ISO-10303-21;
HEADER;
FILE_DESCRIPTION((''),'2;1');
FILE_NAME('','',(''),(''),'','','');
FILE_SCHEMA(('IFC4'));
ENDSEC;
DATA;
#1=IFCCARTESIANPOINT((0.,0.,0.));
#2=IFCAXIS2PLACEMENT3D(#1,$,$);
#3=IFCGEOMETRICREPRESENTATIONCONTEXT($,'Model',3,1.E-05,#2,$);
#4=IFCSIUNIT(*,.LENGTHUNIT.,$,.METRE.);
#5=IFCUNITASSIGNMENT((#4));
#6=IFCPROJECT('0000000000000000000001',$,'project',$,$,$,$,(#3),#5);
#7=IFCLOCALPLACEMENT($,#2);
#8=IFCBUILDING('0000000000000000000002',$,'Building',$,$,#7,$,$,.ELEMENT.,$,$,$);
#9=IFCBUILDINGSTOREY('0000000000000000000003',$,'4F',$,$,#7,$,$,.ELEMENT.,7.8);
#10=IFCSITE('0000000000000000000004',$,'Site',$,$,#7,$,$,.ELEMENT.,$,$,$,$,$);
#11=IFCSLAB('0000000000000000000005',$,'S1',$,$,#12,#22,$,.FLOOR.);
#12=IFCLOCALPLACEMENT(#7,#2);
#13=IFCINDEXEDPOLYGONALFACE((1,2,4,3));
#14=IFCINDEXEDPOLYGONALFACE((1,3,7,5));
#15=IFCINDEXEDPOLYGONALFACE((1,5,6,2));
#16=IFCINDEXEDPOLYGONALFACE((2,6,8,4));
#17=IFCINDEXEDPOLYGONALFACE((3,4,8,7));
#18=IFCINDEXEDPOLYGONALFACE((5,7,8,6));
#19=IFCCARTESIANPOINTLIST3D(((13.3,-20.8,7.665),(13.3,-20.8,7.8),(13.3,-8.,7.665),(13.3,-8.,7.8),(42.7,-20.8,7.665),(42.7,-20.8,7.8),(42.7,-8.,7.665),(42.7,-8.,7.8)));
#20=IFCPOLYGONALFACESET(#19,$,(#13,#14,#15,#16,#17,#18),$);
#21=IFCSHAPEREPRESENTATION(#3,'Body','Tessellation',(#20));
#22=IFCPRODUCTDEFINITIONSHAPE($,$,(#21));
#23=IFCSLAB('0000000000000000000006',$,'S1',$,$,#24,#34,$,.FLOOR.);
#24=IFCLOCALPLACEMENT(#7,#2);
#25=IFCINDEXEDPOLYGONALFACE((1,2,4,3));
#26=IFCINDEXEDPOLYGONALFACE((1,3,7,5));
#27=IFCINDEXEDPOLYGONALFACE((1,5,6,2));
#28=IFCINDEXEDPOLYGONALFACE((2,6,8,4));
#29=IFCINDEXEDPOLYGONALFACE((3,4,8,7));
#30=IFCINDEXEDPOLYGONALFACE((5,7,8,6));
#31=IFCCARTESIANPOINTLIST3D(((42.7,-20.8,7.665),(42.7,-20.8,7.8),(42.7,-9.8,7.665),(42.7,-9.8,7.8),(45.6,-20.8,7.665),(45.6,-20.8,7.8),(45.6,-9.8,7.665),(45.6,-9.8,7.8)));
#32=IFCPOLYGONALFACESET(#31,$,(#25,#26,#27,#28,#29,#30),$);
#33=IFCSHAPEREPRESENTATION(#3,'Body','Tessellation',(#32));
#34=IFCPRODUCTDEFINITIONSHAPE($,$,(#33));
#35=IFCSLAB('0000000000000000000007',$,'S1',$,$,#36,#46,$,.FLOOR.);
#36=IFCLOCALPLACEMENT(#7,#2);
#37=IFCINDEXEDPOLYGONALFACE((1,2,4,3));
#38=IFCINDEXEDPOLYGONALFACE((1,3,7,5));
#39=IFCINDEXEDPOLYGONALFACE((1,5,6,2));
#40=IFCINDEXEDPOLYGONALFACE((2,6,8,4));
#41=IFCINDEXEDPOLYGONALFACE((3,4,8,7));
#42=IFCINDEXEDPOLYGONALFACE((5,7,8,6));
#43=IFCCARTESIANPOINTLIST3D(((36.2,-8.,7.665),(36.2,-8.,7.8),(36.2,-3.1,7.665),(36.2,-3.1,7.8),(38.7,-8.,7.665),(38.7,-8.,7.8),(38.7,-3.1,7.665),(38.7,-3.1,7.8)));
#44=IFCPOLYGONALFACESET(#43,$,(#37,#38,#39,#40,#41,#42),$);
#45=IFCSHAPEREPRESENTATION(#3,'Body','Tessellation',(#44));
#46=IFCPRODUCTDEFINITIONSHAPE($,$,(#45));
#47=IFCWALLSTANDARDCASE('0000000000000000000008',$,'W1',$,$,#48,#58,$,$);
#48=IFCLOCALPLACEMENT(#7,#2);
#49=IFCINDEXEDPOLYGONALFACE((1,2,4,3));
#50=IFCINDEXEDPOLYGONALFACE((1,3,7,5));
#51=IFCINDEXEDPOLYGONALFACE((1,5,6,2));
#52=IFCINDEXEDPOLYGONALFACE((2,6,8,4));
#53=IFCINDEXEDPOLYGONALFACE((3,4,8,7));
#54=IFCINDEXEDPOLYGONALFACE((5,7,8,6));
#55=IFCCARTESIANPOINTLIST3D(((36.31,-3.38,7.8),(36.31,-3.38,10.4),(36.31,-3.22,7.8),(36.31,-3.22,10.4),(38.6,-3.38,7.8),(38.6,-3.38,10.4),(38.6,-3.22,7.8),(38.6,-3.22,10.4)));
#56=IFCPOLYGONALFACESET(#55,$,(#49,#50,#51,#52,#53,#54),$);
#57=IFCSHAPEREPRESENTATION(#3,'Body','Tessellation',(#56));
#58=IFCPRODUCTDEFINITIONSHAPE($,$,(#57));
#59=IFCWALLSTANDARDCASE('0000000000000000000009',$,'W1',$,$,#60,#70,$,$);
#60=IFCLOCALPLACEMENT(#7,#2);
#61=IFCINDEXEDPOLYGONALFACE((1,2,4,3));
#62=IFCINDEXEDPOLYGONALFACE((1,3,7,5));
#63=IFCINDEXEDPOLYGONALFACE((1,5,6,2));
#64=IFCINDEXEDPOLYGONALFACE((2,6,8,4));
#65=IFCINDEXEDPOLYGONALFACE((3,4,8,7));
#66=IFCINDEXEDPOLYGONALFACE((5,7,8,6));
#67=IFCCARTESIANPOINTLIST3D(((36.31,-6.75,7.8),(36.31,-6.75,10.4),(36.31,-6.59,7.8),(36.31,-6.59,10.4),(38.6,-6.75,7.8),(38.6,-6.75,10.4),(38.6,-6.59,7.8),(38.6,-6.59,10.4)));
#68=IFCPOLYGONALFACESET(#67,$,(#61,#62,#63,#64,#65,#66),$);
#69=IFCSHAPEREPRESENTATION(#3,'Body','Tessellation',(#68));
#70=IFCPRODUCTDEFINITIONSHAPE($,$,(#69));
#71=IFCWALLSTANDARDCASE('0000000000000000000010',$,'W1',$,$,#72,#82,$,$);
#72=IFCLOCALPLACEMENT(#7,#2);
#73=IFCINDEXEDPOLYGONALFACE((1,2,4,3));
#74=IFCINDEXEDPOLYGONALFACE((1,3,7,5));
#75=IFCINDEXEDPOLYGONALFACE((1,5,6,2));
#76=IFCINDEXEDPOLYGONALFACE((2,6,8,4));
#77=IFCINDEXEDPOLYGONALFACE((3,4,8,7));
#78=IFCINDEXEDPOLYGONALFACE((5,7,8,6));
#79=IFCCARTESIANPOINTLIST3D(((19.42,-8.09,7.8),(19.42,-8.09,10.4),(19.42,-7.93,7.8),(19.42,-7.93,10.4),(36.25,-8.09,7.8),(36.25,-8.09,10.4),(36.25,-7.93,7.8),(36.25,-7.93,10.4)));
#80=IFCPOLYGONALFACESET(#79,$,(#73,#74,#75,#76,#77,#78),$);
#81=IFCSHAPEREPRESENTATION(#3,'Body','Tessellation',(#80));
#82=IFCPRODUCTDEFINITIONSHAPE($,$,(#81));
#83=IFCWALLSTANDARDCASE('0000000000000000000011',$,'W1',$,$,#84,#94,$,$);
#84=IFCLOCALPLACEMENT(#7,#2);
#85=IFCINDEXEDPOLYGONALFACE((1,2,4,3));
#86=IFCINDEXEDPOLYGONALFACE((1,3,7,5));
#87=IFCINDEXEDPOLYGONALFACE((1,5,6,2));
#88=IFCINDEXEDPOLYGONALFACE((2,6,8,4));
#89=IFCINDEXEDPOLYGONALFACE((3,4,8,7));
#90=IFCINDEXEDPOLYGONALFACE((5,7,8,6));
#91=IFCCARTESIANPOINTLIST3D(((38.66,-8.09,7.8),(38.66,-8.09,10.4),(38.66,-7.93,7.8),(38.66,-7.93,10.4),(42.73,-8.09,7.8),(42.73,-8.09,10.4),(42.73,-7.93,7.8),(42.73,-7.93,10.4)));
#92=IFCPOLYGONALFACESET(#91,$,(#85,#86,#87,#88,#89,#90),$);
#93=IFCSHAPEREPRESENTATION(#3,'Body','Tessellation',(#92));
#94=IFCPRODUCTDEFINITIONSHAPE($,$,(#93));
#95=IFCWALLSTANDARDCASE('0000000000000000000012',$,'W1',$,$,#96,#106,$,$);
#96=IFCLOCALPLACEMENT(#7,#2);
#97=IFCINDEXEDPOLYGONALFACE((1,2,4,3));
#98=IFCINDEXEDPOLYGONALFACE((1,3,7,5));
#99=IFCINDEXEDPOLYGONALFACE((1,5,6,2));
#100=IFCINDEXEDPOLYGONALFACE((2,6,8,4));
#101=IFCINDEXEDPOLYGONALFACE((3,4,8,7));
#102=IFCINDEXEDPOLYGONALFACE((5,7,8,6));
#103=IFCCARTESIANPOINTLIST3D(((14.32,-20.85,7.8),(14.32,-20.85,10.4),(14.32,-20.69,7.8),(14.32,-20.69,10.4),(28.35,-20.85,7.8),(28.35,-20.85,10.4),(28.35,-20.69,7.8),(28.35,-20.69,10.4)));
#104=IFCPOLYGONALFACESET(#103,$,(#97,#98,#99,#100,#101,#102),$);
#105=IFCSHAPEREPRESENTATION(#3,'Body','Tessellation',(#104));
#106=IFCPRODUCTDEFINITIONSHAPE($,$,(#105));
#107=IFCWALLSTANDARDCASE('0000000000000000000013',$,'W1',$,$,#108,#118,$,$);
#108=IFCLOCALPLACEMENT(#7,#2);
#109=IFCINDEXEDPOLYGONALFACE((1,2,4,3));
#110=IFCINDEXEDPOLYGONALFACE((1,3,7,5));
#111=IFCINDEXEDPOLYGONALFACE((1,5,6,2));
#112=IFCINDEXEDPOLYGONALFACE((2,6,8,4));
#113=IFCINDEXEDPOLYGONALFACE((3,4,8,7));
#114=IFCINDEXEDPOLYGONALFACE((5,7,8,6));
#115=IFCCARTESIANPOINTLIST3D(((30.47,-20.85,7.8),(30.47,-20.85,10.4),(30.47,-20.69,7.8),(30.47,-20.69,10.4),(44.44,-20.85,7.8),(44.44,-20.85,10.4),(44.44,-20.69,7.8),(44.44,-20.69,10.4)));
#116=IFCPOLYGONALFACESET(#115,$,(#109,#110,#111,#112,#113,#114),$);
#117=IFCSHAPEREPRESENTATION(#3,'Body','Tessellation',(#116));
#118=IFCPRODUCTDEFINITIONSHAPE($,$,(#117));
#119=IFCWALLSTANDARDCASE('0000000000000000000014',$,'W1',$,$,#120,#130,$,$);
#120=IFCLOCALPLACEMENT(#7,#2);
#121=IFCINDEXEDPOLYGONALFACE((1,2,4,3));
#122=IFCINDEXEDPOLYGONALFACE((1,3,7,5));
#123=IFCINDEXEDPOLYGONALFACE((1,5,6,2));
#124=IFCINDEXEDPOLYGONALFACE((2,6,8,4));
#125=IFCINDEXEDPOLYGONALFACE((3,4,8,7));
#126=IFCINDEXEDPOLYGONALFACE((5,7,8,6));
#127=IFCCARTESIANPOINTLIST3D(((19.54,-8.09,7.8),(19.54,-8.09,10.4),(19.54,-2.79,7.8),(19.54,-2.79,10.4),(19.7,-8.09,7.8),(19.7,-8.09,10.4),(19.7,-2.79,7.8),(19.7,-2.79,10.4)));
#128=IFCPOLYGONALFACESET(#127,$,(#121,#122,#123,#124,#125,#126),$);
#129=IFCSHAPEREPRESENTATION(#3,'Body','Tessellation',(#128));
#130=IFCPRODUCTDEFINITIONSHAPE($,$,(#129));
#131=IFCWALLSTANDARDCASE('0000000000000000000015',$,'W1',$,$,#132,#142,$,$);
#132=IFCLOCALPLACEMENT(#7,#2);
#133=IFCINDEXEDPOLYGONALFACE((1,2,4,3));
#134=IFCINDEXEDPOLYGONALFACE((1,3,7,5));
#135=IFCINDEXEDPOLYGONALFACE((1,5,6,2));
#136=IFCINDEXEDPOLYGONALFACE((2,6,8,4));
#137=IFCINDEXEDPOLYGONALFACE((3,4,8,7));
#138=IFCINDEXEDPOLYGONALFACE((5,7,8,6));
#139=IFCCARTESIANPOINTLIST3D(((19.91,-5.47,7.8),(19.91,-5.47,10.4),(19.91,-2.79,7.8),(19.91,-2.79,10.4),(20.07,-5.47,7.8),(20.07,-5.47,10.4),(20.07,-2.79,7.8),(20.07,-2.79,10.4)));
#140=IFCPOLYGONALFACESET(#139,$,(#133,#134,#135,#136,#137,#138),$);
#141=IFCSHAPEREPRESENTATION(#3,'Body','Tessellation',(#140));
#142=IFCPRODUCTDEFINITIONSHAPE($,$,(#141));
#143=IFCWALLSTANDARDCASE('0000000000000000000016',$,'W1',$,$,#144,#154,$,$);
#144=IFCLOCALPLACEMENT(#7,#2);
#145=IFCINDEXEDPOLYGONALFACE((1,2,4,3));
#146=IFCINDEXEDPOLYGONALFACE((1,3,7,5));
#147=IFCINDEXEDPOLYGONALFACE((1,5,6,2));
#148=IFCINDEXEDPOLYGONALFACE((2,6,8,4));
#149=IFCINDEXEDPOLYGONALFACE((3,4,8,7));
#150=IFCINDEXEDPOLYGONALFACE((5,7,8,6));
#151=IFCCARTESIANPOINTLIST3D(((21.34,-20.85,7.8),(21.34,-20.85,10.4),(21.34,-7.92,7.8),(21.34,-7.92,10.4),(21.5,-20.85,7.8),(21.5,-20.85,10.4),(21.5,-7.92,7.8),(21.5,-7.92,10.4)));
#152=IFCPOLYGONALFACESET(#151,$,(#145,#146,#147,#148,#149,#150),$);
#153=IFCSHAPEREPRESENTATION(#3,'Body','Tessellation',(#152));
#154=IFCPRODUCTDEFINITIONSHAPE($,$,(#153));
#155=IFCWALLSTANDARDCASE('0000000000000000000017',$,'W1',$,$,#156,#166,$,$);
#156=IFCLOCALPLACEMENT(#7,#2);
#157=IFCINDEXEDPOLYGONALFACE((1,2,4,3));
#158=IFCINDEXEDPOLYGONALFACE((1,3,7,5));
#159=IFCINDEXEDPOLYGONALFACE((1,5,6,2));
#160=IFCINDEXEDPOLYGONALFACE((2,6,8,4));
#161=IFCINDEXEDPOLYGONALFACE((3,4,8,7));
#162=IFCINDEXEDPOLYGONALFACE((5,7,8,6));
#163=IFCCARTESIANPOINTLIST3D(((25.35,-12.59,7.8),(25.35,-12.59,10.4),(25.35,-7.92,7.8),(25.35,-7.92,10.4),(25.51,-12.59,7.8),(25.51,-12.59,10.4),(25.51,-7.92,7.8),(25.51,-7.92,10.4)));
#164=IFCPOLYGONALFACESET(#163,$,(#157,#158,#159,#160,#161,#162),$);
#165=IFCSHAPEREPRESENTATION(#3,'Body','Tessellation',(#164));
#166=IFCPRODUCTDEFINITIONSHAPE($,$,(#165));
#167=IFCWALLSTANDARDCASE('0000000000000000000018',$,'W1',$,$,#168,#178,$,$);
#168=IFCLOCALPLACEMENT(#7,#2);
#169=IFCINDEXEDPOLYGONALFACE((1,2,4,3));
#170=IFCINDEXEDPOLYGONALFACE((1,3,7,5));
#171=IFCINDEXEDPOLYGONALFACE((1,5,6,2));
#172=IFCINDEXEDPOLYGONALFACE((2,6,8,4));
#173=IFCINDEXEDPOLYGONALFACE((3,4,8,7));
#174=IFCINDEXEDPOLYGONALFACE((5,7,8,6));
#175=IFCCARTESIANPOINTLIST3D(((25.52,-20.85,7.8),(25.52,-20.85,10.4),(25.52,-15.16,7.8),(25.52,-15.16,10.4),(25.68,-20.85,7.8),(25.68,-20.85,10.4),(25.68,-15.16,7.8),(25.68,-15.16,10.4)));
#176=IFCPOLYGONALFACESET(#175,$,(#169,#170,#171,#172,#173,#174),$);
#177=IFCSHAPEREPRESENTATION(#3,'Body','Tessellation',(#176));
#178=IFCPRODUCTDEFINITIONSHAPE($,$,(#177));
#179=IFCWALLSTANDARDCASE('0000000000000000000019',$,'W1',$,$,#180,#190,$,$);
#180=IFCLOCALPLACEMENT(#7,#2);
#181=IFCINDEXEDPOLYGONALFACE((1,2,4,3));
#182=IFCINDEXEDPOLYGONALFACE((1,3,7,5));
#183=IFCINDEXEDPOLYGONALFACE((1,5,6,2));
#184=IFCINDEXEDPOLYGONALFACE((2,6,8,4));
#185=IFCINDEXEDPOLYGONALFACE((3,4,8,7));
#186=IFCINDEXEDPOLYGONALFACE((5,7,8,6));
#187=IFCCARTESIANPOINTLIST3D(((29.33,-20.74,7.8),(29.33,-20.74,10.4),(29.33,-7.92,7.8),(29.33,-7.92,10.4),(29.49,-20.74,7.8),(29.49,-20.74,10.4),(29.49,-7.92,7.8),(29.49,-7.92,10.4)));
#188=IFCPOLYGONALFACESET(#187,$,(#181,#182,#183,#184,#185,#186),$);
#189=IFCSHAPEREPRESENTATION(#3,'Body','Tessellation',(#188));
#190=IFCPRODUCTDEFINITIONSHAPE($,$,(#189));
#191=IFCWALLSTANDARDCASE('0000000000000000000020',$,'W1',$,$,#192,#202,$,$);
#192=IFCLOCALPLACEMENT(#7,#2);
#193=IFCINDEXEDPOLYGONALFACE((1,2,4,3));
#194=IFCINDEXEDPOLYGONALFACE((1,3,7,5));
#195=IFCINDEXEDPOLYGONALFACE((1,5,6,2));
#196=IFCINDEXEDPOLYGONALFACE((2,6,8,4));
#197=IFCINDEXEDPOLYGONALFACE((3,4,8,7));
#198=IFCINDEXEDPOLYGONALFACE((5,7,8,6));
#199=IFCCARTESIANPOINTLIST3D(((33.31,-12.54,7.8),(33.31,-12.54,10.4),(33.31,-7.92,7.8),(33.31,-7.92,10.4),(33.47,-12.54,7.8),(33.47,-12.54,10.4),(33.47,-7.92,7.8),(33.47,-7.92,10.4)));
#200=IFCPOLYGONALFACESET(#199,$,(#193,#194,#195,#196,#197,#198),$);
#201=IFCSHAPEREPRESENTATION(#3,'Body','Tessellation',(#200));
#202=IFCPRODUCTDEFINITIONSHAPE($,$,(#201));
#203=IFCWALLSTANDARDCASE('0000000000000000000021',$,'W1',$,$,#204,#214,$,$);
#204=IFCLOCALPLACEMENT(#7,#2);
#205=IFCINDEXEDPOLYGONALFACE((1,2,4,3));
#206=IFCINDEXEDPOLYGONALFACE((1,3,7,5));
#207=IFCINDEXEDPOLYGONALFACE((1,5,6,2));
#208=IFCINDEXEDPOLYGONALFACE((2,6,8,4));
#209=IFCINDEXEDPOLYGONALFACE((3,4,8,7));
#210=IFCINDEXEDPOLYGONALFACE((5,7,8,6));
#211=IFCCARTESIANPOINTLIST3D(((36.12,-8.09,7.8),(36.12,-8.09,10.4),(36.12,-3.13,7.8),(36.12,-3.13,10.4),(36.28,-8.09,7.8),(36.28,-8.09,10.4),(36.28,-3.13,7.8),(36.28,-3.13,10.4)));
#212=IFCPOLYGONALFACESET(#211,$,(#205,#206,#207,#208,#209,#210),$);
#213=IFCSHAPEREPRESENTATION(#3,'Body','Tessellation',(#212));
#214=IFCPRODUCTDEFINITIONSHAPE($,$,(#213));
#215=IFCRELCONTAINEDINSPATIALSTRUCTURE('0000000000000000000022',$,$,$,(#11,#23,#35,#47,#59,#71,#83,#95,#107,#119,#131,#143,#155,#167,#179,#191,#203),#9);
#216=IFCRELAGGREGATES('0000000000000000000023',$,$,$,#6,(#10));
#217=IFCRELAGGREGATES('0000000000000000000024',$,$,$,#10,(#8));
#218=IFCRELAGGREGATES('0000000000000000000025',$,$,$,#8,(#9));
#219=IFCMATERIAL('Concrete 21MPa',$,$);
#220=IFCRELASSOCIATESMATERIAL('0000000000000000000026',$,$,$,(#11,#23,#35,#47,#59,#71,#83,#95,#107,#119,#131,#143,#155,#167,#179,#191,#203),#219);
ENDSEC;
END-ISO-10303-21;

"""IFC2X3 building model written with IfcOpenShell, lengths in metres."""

from ifc_helpers import new_model, si_unit, frame, origin, origin_2d, place, context, project, spatial, rectangle, extrude, material, element, save


model = new_model("IFC2X3")

# Units and contexts
model_context = context("Model", 3, precision=1e-05, world=origin())
ifc_project = project(units=[si_unit("LENGTHUNIT", "METRE")], contexts=[model_context])

# Site, building, storey
placement = place(None, origin())
site = spatial("IfcSite", under=ifc_project, at=placement, Name="Site", CompositionType="ELEMENT")
building = spatial("IfcBuilding", under=site, at=placement, Name="Building", CompositionType="ELEMENT")
storey = spatial("IfcBuildingStorey", under=building, at=placement, Name="4F", CompositionType="ELEMENT", Elevation=7.8)

# Slabs
ifc_material_1 = material(Name="Concrete 21MPa")
slab_1_placement = place(None, frame((28.0, -14.4, 7.665)))
element("IfcSlab", 1, at=slab_1_placement, inside=storey, material=ifc_material_1, Name="S1", PredefinedType="FLOOR", context=model_context, shape_type="SweptSolid", body=[
    extrude(rectangle(XDim=29.4, YDim=12.8, at=origin_2d()), origin(), (0.0, 0.0, 1.0), 0.135),
])
slab_2_placement = place(None, frame((44.15, -15.3, 7.665)))
element("IfcSlab", 2, at=slab_2_placement, inside=storey, material=ifc_material_1, Name="S1", PredefinedType="FLOOR", context=model_context, shape_type="SweptSolid", body=[
    extrude(rectangle(XDim=2.9, YDim=11.0, at=origin_2d()), origin(), (0.0, 0.0, 1.0), 0.135),
])
slab_3_placement = place(None, frame((37.45, -5.55, 7.665)))
element("IfcSlab", 3, at=slab_3_placement, inside=storey, material=ifc_material_1, Name="S1", PredefinedType="FLOOR", context=model_context, shape_type="SweptSolid", body=[
    extrude(rectangle(XDim=2.5, YDim=4.9, at=origin_2d()), origin(), (0.0, 0.0, 1.0), 0.135),
])

# Walls
for number, where, name in (
    (4, (37.455, -3.3, 7.8), "W1"),
    (5, (37.455, -6.67, 7.8), "W1"),
):
    element("IfcWallStandardCase", number, at=place(None, frame(where)), inside=storey, material=ifc_material_1, Name=name, context=model_context, shape_type="SweptSolid", body=[
        extrude(rectangle(XDim=2.29, YDim=0.16, at=origin_2d()), origin(), (0.0, 0.0, 1.0), 2.6),
    ])
wall_1_placement = place(None, frame((27.835, -8.01, 7.8)))
element("IfcWallStandardCase", 6, at=wall_1_placement, inside=storey, material=ifc_material_1, Name="W1", context=model_context, shape_type="SweptSolid", body=[
    extrude(rectangle(XDim=16.83, YDim=0.16, at=origin_2d()), origin(), (0.0, 0.0, 1.0), 2.6),
])
wall_2_placement = place(None, frame((40.695, -8.01, 7.8)))
element("IfcWallStandardCase", 7, at=wall_2_placement, inside=storey, material=ifc_material_1, Name="W1", context=model_context, shape_type="SweptSolid", body=[
    extrude(rectangle(XDim=4.07, YDim=0.16, at=origin_2d()), origin(), (0.0, 0.0, 1.0), 2.6),
])
wall_3_placement = place(None, frame((21.335, -20.77, 7.8)))
element("IfcWallStandardCase", 8, at=wall_3_placement, inside=storey, material=ifc_material_1, Name="W1", context=model_context, shape_type="SweptSolid", body=[
    extrude(rectangle(XDim=14.03, YDim=0.16, at=origin_2d()), origin(), (0.0, 0.0, 1.0), 2.6),
])
wall_4_placement = place(None, frame((37.455, -20.77, 7.8)))
element("IfcWallStandardCase", 9, at=wall_4_placement, inside=storey, material=ifc_material_1, Name="W1", context=model_context, shape_type="SweptSolid", body=[
    extrude(rectangle(XDim=13.97, YDim=0.16, at=origin_2d()), origin(), (0.0, 0.0, 1.0), 2.6),
])
wall_5_placement = place(None, frame((19.62, -5.44, 7.8)))
element("IfcWallStandardCase", 10, at=wall_5_placement, inside=storey, material=ifc_material_1, Name="W1", context=model_context, shape_type="SweptSolid", body=[
    extrude(rectangle(XDim=0.16, YDim=5.3, at=origin_2d()), origin(), (0.0, 0.0, 1.0), 2.6),
])
wall_6_placement = place(None, frame((19.99, -4.13, 7.8)))
element("IfcWallStandardCase", 11, at=wall_6_placement, inside=storey, material=ifc_material_1, Name="W1", context=model_context, shape_type="SweptSolid", body=[
    extrude(rectangle(XDim=0.16, YDim=2.68, at=origin_2d()), origin(), (0.0, 0.0, 1.0), 2.6),
])
wall_7_placement = place(None, frame((21.42, -14.385, 7.8)))
element("IfcWallStandardCase", 12, at=wall_7_placement, inside=storey, material=ifc_material_1, Name="W1", context=model_context, shape_type="SweptSolid", body=[
    extrude(rectangle(XDim=0.16, YDim=12.93, at=origin_2d()), origin(), (0.0, 0.0, 1.0), 2.6),
])
wall_8_placement = place(None, frame((25.43, -10.255, 7.8)))
element("IfcWallStandardCase", 13, at=wall_8_placement, inside=storey, material=ifc_material_1, Name="W1", context=model_context, shape_type="SweptSolid", body=[
    extrude(rectangle(XDim=0.16, YDim=4.67, at=origin_2d()), origin(), (0.0, 0.0, 1.0), 2.6),
])
wall_9_placement = place(None, frame((25.6, -18.005, 7.8)))
element("IfcWallStandardCase", 14, at=wall_9_placement, inside=storey, material=ifc_material_1, Name="W1", context=model_context, shape_type="SweptSolid", body=[
    extrude(rectangle(XDim=0.16, YDim=5.69, at=origin_2d()), origin(), (0.0, 0.0, 1.0), 2.6),
])
wall_10_placement = place(None, frame((29.41, -14.33, 7.8)))
element("IfcWallStandardCase", 15, at=wall_10_placement, inside=storey, material=ifc_material_1, Name="W1", context=model_context, shape_type="SweptSolid", body=[
    extrude(rectangle(XDim=0.16, YDim=12.82, at=origin_2d()), origin(), (0.0, 0.0, 1.0), 2.6),
])
wall_11_placement = place(None, frame((33.39, -10.23, 7.8)))
element("IfcWallStandardCase", 16, at=wall_11_placement, inside=storey, material=ifc_material_1, Name="W1", context=model_context, shape_type="SweptSolid", body=[
    extrude(rectangle(XDim=0.16, YDim=4.62, at=origin_2d()), origin(), (0.0, 0.0, 1.0), 2.6),
])
wall_12_placement = place(None, frame((36.2, -5.61, 7.8)))
element("IfcWallStandardCase", 17, at=wall_12_placement, inside=storey, material=ifc_material_1, Name="W1", context=model_context, shape_type="SweptSolid", body=[
    extrude(rectangle(XDim=0.16, YDim=4.96, at=origin_2d()), origin(), (0.0, 0.0, 1.0), 2.6),
])

save(model, "model.ifc")
